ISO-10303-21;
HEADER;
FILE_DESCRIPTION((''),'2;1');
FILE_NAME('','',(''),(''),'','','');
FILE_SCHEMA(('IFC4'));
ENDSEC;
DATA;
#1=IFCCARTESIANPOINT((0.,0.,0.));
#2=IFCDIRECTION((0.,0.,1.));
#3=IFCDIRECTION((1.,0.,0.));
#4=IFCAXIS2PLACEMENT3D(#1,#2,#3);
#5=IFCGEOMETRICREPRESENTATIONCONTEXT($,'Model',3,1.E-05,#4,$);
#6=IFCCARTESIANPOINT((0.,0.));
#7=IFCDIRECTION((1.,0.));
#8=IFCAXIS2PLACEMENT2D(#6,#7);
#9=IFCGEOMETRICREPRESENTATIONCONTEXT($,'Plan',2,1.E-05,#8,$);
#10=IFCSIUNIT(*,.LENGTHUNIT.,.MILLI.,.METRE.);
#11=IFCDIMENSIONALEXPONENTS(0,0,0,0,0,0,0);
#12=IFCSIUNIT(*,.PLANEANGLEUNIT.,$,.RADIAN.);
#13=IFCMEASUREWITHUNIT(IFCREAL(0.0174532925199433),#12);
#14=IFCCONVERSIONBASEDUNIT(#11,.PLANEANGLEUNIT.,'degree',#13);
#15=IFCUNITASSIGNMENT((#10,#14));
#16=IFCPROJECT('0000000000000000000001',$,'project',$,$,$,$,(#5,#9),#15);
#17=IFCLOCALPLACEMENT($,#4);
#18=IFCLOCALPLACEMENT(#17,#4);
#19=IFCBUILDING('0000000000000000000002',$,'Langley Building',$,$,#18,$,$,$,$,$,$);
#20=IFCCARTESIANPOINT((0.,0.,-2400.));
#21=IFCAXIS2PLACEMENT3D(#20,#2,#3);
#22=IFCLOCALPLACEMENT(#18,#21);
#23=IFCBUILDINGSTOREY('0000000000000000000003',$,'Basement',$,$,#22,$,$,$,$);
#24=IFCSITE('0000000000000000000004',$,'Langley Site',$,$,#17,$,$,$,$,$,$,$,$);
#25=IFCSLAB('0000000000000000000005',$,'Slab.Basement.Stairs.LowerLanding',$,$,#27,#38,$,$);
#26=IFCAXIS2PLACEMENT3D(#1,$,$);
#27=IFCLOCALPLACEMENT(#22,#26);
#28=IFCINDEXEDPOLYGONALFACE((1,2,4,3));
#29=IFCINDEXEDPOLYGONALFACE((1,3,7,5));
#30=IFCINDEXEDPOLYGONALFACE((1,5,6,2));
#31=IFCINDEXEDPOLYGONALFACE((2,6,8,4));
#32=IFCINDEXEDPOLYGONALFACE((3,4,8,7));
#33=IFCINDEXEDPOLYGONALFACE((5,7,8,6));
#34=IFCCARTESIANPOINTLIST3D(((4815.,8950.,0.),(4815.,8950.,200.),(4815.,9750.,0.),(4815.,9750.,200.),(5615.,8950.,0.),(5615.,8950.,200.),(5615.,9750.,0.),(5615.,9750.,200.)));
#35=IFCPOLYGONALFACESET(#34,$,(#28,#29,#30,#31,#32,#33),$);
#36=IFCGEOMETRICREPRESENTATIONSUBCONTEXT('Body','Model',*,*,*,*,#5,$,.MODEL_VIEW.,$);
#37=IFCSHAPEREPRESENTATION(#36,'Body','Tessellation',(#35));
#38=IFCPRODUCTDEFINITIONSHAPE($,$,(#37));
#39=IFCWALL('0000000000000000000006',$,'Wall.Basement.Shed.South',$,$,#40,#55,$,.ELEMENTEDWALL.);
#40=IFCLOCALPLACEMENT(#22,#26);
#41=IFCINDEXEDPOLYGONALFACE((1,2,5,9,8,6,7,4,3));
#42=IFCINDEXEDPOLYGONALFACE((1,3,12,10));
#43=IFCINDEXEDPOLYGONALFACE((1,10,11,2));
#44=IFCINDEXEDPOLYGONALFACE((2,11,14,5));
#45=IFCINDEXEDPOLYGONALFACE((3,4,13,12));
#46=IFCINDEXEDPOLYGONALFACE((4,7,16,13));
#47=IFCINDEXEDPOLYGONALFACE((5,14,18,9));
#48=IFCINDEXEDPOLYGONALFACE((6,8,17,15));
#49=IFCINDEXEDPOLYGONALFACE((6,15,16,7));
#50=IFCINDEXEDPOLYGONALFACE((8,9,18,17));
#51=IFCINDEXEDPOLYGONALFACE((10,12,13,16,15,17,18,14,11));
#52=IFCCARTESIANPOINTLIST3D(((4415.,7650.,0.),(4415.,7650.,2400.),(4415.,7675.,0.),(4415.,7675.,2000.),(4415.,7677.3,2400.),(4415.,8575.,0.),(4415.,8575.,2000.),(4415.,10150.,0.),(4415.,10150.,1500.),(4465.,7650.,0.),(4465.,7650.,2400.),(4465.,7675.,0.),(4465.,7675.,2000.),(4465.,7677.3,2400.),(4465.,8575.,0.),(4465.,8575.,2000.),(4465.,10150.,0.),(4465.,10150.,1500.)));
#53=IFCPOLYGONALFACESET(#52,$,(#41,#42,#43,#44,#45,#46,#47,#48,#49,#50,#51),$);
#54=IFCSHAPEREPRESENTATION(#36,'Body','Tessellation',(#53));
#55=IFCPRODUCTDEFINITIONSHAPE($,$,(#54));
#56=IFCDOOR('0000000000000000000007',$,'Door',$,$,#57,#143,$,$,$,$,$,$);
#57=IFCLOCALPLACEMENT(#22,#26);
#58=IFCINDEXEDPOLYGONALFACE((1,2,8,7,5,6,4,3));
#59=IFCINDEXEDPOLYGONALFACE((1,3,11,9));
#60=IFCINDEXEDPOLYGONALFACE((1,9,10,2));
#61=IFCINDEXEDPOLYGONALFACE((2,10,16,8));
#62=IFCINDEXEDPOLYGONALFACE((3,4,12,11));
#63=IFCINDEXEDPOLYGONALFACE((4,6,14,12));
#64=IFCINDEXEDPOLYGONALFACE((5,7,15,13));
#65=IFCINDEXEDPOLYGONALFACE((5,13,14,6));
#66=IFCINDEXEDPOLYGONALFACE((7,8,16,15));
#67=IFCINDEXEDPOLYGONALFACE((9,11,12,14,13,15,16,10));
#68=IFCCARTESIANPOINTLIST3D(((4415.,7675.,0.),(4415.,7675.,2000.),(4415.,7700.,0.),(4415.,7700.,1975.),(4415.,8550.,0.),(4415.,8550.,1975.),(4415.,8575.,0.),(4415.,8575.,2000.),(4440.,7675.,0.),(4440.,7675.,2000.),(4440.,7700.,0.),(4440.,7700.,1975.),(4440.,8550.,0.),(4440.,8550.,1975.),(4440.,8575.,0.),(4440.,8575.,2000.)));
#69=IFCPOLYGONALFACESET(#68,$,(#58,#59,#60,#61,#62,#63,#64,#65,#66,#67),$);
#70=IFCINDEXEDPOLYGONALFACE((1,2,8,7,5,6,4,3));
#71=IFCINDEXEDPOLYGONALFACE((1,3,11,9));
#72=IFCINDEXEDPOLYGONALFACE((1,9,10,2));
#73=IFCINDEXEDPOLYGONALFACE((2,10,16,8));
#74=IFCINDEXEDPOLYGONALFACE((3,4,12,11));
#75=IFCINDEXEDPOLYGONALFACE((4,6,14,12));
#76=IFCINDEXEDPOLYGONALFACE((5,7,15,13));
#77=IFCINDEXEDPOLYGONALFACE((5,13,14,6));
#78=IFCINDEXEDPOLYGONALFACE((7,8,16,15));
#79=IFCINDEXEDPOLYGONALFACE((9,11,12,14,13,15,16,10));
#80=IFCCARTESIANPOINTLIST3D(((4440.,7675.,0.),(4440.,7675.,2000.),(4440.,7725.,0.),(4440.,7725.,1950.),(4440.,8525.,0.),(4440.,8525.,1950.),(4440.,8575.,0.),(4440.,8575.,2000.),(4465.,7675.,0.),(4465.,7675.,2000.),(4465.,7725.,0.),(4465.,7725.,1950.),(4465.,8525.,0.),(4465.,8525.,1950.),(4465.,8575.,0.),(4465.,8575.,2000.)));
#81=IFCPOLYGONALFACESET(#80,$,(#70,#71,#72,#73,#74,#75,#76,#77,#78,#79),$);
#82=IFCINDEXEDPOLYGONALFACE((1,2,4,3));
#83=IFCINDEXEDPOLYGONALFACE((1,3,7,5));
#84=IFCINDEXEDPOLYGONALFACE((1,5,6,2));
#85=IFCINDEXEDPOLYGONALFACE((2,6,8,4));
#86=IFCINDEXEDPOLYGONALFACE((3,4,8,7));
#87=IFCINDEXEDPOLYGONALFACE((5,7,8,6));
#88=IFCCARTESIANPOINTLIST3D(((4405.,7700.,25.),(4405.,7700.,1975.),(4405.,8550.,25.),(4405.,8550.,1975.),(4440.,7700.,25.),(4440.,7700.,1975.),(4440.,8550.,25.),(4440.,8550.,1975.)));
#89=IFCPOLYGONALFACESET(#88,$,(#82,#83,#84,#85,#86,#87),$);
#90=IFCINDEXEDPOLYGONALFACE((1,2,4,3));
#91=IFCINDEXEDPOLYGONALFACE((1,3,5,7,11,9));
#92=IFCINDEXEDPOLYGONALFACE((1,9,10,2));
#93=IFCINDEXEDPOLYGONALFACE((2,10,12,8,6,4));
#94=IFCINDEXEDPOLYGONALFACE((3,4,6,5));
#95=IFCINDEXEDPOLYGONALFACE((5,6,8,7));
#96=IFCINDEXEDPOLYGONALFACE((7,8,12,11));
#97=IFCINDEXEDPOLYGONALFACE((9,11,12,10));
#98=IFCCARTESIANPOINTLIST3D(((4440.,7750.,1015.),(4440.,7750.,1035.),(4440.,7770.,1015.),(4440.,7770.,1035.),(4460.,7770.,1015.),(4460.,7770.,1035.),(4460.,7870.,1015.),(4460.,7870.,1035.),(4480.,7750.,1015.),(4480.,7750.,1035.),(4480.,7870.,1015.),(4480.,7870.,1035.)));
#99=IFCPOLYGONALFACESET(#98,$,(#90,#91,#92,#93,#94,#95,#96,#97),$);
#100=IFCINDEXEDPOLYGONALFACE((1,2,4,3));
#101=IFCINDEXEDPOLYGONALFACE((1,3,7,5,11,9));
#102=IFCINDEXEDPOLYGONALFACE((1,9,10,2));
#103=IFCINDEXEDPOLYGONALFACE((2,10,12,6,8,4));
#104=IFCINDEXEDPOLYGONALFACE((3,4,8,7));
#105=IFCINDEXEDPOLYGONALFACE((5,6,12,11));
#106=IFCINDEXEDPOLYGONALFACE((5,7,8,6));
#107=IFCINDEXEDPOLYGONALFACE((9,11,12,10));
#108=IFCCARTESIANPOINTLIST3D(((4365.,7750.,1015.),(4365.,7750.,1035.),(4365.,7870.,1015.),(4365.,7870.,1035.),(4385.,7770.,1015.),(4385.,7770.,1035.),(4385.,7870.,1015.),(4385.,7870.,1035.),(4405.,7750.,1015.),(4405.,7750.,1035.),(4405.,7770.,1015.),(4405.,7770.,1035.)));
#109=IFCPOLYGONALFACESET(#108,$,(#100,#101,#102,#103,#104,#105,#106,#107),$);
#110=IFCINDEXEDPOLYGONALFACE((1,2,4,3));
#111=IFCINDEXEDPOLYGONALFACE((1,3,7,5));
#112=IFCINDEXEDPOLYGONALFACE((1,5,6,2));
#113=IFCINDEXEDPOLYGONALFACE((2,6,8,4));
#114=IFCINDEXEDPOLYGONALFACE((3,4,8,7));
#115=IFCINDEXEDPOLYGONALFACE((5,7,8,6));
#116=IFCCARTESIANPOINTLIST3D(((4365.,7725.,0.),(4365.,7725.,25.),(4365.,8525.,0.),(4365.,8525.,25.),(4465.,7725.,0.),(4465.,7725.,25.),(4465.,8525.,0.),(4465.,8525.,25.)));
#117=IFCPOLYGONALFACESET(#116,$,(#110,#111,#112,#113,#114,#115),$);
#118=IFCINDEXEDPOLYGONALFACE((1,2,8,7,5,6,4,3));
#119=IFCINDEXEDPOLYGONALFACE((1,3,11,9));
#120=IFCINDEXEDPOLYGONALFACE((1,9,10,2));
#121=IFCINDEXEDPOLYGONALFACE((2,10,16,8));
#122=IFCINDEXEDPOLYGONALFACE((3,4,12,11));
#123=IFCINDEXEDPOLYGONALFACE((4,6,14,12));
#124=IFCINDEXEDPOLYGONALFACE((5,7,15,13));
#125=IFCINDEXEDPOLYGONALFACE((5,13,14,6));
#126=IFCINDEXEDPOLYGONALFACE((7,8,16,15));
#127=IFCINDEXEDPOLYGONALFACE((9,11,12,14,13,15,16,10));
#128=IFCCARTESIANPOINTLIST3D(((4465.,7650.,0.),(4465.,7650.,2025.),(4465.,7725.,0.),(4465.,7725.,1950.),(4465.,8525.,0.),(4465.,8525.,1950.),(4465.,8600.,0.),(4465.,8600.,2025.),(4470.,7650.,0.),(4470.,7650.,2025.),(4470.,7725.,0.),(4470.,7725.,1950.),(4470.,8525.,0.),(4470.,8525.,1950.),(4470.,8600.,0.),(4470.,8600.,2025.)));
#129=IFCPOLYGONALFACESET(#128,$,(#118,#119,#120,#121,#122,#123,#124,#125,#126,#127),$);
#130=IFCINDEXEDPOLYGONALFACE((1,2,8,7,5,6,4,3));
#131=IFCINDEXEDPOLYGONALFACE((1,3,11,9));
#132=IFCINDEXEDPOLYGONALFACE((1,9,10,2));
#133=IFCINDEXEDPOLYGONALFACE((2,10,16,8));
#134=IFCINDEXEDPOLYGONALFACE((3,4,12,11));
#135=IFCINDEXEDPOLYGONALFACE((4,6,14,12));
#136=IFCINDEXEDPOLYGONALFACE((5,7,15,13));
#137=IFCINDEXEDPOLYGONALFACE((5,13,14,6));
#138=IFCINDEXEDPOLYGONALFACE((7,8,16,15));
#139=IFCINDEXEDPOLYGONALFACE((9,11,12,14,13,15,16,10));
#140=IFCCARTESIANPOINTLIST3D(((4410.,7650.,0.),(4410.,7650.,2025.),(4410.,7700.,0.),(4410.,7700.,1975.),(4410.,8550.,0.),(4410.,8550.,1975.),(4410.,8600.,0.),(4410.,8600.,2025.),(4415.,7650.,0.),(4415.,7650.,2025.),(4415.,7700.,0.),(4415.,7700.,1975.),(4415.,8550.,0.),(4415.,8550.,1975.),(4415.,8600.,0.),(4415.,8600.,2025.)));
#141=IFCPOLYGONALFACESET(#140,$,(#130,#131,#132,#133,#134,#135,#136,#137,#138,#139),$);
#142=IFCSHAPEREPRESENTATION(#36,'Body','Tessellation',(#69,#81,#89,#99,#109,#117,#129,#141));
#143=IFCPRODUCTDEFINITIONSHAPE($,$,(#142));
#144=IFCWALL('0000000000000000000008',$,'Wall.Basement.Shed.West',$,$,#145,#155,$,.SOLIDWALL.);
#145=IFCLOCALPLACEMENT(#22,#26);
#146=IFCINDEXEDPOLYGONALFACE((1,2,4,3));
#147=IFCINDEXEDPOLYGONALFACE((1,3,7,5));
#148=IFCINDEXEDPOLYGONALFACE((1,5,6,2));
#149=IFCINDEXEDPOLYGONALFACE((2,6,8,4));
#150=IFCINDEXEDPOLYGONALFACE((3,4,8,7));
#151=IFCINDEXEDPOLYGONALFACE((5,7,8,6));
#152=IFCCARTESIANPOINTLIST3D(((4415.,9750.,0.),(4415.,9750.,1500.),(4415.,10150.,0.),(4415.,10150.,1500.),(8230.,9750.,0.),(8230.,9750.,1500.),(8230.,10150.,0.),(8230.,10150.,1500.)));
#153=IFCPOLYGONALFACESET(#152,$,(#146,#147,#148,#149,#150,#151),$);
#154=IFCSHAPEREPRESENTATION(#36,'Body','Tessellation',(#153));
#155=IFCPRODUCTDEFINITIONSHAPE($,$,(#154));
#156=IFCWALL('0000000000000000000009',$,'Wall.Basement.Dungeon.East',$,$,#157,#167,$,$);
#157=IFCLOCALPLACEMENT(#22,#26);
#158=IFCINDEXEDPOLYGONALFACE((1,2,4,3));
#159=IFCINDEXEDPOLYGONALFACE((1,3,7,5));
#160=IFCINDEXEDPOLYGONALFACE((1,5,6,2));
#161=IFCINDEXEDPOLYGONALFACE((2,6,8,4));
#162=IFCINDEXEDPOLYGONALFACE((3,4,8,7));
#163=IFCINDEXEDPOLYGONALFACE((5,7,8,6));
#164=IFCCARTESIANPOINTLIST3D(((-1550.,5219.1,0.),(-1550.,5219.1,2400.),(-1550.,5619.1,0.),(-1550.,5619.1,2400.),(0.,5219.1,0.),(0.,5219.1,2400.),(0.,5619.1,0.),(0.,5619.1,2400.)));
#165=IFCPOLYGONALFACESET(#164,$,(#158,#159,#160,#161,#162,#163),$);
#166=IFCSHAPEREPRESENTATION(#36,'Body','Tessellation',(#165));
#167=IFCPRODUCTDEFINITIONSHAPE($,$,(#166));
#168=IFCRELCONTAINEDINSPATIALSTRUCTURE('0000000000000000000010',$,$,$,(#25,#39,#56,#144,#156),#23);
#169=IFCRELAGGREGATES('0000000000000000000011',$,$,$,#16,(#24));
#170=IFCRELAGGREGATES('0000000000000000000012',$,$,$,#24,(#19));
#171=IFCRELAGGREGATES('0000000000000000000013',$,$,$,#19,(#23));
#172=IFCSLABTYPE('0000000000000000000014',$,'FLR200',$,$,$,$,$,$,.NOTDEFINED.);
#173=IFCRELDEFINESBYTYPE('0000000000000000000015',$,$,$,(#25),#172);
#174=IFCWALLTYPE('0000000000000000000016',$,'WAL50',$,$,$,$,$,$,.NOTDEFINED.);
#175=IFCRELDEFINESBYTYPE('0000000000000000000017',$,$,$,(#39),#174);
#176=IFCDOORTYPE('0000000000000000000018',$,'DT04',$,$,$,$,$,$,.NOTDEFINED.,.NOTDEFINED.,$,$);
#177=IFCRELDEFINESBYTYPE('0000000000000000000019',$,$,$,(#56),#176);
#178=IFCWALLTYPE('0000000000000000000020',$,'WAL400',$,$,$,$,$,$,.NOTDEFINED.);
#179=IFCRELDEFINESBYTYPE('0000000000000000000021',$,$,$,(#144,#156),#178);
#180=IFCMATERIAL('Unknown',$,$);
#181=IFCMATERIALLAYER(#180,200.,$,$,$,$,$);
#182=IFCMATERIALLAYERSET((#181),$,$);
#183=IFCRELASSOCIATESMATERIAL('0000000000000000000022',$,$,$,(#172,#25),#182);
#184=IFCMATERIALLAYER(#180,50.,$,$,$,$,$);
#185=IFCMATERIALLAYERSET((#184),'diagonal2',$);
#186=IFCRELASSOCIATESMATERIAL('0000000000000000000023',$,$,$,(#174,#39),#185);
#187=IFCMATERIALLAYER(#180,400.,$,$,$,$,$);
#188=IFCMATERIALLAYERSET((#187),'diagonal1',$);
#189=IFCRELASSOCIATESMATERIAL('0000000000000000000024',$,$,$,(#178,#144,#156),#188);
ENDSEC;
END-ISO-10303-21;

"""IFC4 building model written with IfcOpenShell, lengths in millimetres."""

from ifc_helpers import new_model, entity, si_unit, converted_unit, frame, origin_with_axes, origin_2d_with_axis, place, context, subcontext, project, spatial, line, indexed_curve, outline, extrude, clip, halfspace, shape, source, transform, mapped, material, layer, layer_set, layer_usage, type_object, type_shapes, element, fill, save


model = new_model("IFC4")

# Units and contexts
model_context = context("Model", 3, precision=1e-05, world=origin_with_axes())
plan_context = context("Plan", 2, precision=1e-05, world=origin_2d_with_axis())
body_context_1 = subcontext(model_context, "Body", "Model", "MODEL_VIEW")
body_context_2 = subcontext(plan_context, "Body", "Plan", "PLAN_VIEW")
ifc_project = project(units=[si_unit("LENGTHUNIT", "METRE", prefix="MILLI"), converted_unit("PLANEANGLEUNIT", "degree", entity("IfcReal", 0.0174532925199433), si_unit("PLANEANGLEUNIT", "RADIAN"), dimensions=[0, 0, 0, 0, 0, 0, 0])], contexts=[model_context, plan_context])

# Site, building, storey
site_placement = place(None, origin_with_axes())
site = spatial("IfcSite", under=ifc_project, at=site_placement, Name="Langley Site")
building_placement = place(site_placement, origin_with_axes())
building = spatial("IfcBuilding", under=site, at=building_placement, Name="Langley Building")
storey_placement = place(building_placement, frame((0.0, 0.0, -2400.0), z_axis=(0.0, 0.0, 1.0), x_axis=(1.0, 0.0, 0.0)))
storey = spatial("IfcBuildingStorey", under=building, at=storey_placement, Name="Basement")

# Slab
ifc_material = material(Name="Unknown")
ifc_layer_1 = layer(ifc_material, 200.0)
ifc_layer_set_1 = layer_set([ifc_layer_1])
ifc_layer_usage_1 = layer_usage(ifc_layer_set_1, "AXIS3", "POSITIVE", -200.0)
slab_type = type_object("IfcSlabType", Name="FLR200", PredefinedType="NOTDEFINED", material=ifc_layer_set_1)
slab_placement = place(storey_placement, frame((4815.0, 8950.0, 200.0), z_axis=(0.0, 0.0, 1.0), x_axis=(1.0, 0.0, 0.0)))
element("IfcSlab", 1, at=slab_placement, inside=storey, type_object=slab_type, material=ifc_layer_usage_1, Name="Slab.Basement.Stairs.LowerLanding", context=body_context_1, shape_type="SweptSolid", body=[
    extrude(outline(indexed_curve([(0.0, 0.0), (800.0, 0.0), (800.0, 800.0), (0.0, 800.0), (0.0, 0.0)])), frame((0.0, 0.0, -200.0), z_axis=(0.0, 0.0, 1.0), x_axis=(1.0, 0.0, 0.0)), (0.0, 0.0, 1.0), 200.0),
])

# Wall, opening, door
ifc_layer_2 = layer(ifc_material, 50.0)
ifc_layer_set_2 = layer_set([ifc_layer_2], Name="diagonal2")
ifc_layer_usage_2 = layer_usage(ifc_layer_set_2, "AXIS2", "POSITIVE", 0.0)
wall_type_1 = type_object("IfcWallType", Name="WAL50", PredefinedType="NOTDEFINED", material=ifc_layer_set_2)
wall_1_placement = place(storey_placement, frame((4415.0, 10150.0, 0.0), z_axis=(0.0, 0.0, 1.0), x_axis=(0.0, -1.0, 0.0)))
wall_1 = element("IfcWall", 2, at=wall_1_placement, inside=storey, type_object=wall_type_1, material=ifc_layer_usage_2, Name="Wall.Basement.Shed.South", PredefinedType="ELEMENTEDWALL", context=body_context_1, shape_type="Clipping", body=[
    clip(extrude(outline(indexed_curve([(0.0, 0.0), (0.0, 50.0), (2500.0, 50.0), (2500.0, 0.0)], segments=[line(1, 2, 3, 4, 1)])), origin_with_axes(), (0.0, 0.0, 1.0), 2400.0), halfspace(frame((0.0, -450.0, 1500.0), z_axis=(-0.34202, 0.0, 0.939693), x_axis=(-0.939693, 0.0, -0.34202)), False)),
])
shared_shape_1 = source(origin_with_axes(), body_context_1, "Body", "SweptSolid", [
    extrude(outline(indexed_curve([(0.0, 0.0), (900.0, 0.0), (900.0, 2000.0), (0.0, 2000.0)], segments=[line(1, 2, 3, 4, 1)])), frame((0.0, -600.0, 0.0), z_axis=(0.0, -1.0, 0.0), x_axis=(1.0, 0.0, 0.0)), (0.0, 0.0, -1.0), 1200.0),
])
opening_1_placement = place(wall_1_placement, frame((2475.0, 50.0, 0.0), z_axis=(0.0, 0.0, 1.0), x_axis=(-1.0, 0.0, 0.0)))
opening_1 = element("IfcOpeningElement", 3, at=opening_1_placement, cuts=wall_1, PredefinedType="OPENING", context=body_context_1, shape_type="MappedRepresentation", body=[
    mapped(shared_shape_1, transform((0.0, 0.0, 0.0), x_axis=(1.0, 0.0, 0.0), y_axis=(0.0, 1.0, 0.0), z_axis=(0.0, 0.0, 1.0), scale=1.0)),
])
door_type_1 = type_object("IfcDoorType", Name="DT04", OperationType="NOTDEFINED", PredefinedType="NOTDEFINED")
shared_shape_2 = source(origin_with_axes(), body_context_1, "Body", "SweptSolid", [
    extrude(outline(indexed_curve([(0.0, 0.0), (0.0, 2000.0), (900.0, 2000.0), (900.0, 0.0), (875.0, 0.0), (875.0, 1975.0), (25.0, 1975.0), (25.0, 0.0)], segments=[line(1, 2, 3, 4, 5, 6, 7, 8, 1)])), frame((0.0, 25.0, 0.0), z_axis=(0.0, -1.0, 0.0), x_axis=(1.0, 0.0, 0.0)), (0.0, 0.0, -1.0), 25.0),
    extrude(outline(indexed_curve([(0.0, 0.0), (0.0, 2000.0), (900.0, 2000.0), (900.0, 0.0), (850.0, 0.0), (850.0, 1950.0), (50.0, 1950.0), (50.0, 0.0)], segments=[line(1, 2, 3, 4, 5, 6, 7, 8, 1)])), frame((0.0, 0.0, 0.0), z_axis=(0.0, -1.0, 0.0), x_axis=(1.0, 0.0, 0.0)), (0.0, 0.0, -1.0), 25.0),
    extrude(outline(indexed_curve([(0.0, 0.0), (850.0, 0.0), (850.0, 35.0), (0.0, 35.0)], segments=[line(1, 2, 3, 4, 1)])), frame((25.0, 25.0, 25.0), z_axis=(0.0, 0.0, 1.0), x_axis=(1.0, 0.0, 0.0)), (0.0, 0.0, 1.0), 1950.0),
    extrude(outline(indexed_curve([(0.0, 0.0), (0.0, -40.0), (120.0, -40.0), (120.0, -20.0), (20.0, -20.0), (20.0, 0.0)], segments=[line(1, 2, 3, 4, 5, 6, 1)])), frame((75.0, 25.0, 1015.0), z_axis=(0.0, 0.0, 1.0), x_axis=(1.0, 0.0, 0.0)), (0.0, 0.0, 1.0), 20.0),
    extrude(outline(indexed_curve([(0.0, 0.0), (0.0, 40.0), (120.0, 40.0), (120.0, 20.0), (20.0, 20.0), (20.0, 0.0)], segments=[line(1, 2, 3, 4, 5, 6, 1)])), frame((75.0, 60.0, 1015.0), z_axis=(0.0, 0.0, 1.0), x_axis=(1.0, 0.0, 0.0)), (0.0, 0.0, 1.0), 20.0),
    extrude(outline(indexed_curve([(0.0, 0.0), (800.0, 0.0), (800.0, 100.0), (0.0, 100.0)], segments=[line(1, 2, 3, 4, 1)])), frame((50.0, 0.0, 0.0), z_axis=(0.0, 0.0, 1.0), x_axis=(1.0, 0.0, 0.0)), (0.0, 0.0, 1.0), 25.0),
    extrude(outline(indexed_curve([(0.0, 0.0), (0.0, 2025.0), (950.0, 2025.0), (950.0, 0.0), (875.0, 0.0), (875.0, 1950.0), (75.0, 1950.0), (75.0, 0.0)], segments=[line(1, 2, 3, 4, 5, 6, 7, 8, 1)])), frame((-25.0, -5.0, 0.0), z_axis=(0.0, -1.0, 0.0), x_axis=(1.0, 0.0, 0.0)), (0.0, 0.0, -1.0), 5.0),
    extrude(outline(indexed_curve([(0.0, 0.0), (0.0, 2025.0), (950.0, 2025.0), (950.0, 0.0), (900.0, 0.0), (900.0, 1975.0), (50.0, 1975.0), (50.0, 0.0)], segments=[line(1, 2, 3, 4, 5, 6, 7, 8, 1)])), frame((-25.0, 50.0, 0.0), z_axis=(0.0, -1.0, 0.0), x_axis=(1.0, 0.0, 0.0)), (0.0, 0.0, -1.0), 5.0),
])
shared_shape_3 = source(origin_with_axes(), body_context_2, "Body", "Curve2D", [
    entity("IfcIndexedPolyCurve", entity("IfcCartesianPointList2D", [[0.0, 0.0], [0.0, 50.0], [25.0, 50.0], [25.0, 25.0], [50.0, 25.0], [50.0, 0.0]]), [entity("IfcLineIndex", [1, 2, 3, 4, 5, 6, 1])]),
    entity("IfcIndexedPolyCurve", entity("IfcCartesianPointList2D", [[900.0, 0.0], [900.0, 50.0], [875.0, 50.0], [875.0, 25.0], [850.0, 25.0], [850.0, 0.0]]), [entity("IfcLineIndex", [1, 2, 3, 4, 5, 6, 1])]),
    entity("IfcTrimmedCurve", entity("IfcEllipse", entity("IfcAxis2Placement2D", entity("IfcCartesianPoint", [840.0, 50.0]), entity("IfcDirection", [1.0, 0.0])), 815.0, 850.0), [entity("IfcCartesianPoint", [840.0, 900.0])], [entity("IfcCartesianPoint", [25.0, 50.0])], True, "CARTESIAN"),
    entity("IfcIndexedPolyCurve", entity("IfcCartesianPointList2D", [[875.0, 50.0], [840.0, 50.0], [840.0, 900.0], [875.0, 900.0]]), [entity("IfcLineIndex", [1, 2, 3, 4, 1])]),
])
type_shapes(door_type_1, [shared_shape_2, shared_shape_3])
door_1_placement = place(opening_1_placement, frame((0.0, 0.0, 0.0), z_axis=(0.0, 0.0, 1.0), x_axis=(1.0, 0.0, 0.0)))
door_1 = element("IfcDoor", 4, at=door_1_placement, inside=storey, type_object=door_type_1, Name="Door", shapes=[
    shape(body_context_1, "Body", "MappedRepresentation", [mapped(shared_shape_2, transform((0.0, 0.0, 0.0), x_axis=(1.0, 0.0, 0.0), y_axis=(0.0, 1.0, 0.0), z_axis=(0.0, 0.0, 1.0), scale=1.0))]),
    shape(body_context_2, "Body", "MappedRepresentation", [mapped(shared_shape_3, transform((0.0, 0.0, 0.0), x_axis=(1.0, 0.0, 0.0), y_axis=(0.0, 1.0, 0.0), z_axis=(0.0, 0.0, 1.0), scale=1.0))]),
])
fill(opening_1, door_1)

# Walls
ifc_layer_3 = layer(ifc_material, 400.0)
ifc_layer_set_3 = layer_set([ifc_layer_3], Name="diagonal1")
ifc_layer_usage_3 = layer_usage(ifc_layer_set_3, "AXIS2", "POSITIVE", 0.0)
wall_type_2 = type_object("IfcWallType", Name="WAL400", PredefinedType="NOTDEFINED", material=ifc_layer_set_3)
wall_2_placement = place(storey_placement, frame((8230.0, 10150.0, 0.0), z_axis=(0.0, 0.0, 1.0), x_axis=(-1.0, 0.0, 0.0)))
element("IfcWall", 5, at=wall_2_placement, inside=storey, type_object=wall_type_2, material=ifc_layer_usage_3, Name="Wall.Basement.Shed.West", PredefinedType="SOLIDWALL", context=body_context_1, shape_type="SweptSolid", body=[
    extrude(outline(indexed_curve([(0.0, 0.0), (0.0, 400.0), (3815.0, 400.0), (3815.0, 0.0)], segments=[line(1, 2, 3, 4, 1)])), origin_with_axes(), (0.0, 0.0, 1.0), 1500.0),
])
ifc_layer_usage_4 = layer_usage(ifc_layer_set_3, "AXIS2", "POSITIVE", 0.0)
wall_3_placement = place(storey_placement, frame((0.0, 5619.1, 0.0), z_axis=(0.0, 0.0, 1.0), x_axis=(-1.0, 0.0, 0.0)))
element("IfcWall", 6, at=wall_3_placement, inside=storey, type_object=wall_type_2, material=ifc_layer_usage_4, Name="Wall.Basement.Dungeon.East", context=body_context_1, shape_type="SweptSolid", body=[
    extrude(outline(indexed_curve([(0.0, 0.0), (0.0, 400.0), (1550.0, 400.0), (1550.0, 0.0)], segments=[line(1, 2, 3, 4, 1)])), origin_with_axes(), (0.0, 0.0, 1.0), 2400.0),
])

save(model, "model.ifc")
